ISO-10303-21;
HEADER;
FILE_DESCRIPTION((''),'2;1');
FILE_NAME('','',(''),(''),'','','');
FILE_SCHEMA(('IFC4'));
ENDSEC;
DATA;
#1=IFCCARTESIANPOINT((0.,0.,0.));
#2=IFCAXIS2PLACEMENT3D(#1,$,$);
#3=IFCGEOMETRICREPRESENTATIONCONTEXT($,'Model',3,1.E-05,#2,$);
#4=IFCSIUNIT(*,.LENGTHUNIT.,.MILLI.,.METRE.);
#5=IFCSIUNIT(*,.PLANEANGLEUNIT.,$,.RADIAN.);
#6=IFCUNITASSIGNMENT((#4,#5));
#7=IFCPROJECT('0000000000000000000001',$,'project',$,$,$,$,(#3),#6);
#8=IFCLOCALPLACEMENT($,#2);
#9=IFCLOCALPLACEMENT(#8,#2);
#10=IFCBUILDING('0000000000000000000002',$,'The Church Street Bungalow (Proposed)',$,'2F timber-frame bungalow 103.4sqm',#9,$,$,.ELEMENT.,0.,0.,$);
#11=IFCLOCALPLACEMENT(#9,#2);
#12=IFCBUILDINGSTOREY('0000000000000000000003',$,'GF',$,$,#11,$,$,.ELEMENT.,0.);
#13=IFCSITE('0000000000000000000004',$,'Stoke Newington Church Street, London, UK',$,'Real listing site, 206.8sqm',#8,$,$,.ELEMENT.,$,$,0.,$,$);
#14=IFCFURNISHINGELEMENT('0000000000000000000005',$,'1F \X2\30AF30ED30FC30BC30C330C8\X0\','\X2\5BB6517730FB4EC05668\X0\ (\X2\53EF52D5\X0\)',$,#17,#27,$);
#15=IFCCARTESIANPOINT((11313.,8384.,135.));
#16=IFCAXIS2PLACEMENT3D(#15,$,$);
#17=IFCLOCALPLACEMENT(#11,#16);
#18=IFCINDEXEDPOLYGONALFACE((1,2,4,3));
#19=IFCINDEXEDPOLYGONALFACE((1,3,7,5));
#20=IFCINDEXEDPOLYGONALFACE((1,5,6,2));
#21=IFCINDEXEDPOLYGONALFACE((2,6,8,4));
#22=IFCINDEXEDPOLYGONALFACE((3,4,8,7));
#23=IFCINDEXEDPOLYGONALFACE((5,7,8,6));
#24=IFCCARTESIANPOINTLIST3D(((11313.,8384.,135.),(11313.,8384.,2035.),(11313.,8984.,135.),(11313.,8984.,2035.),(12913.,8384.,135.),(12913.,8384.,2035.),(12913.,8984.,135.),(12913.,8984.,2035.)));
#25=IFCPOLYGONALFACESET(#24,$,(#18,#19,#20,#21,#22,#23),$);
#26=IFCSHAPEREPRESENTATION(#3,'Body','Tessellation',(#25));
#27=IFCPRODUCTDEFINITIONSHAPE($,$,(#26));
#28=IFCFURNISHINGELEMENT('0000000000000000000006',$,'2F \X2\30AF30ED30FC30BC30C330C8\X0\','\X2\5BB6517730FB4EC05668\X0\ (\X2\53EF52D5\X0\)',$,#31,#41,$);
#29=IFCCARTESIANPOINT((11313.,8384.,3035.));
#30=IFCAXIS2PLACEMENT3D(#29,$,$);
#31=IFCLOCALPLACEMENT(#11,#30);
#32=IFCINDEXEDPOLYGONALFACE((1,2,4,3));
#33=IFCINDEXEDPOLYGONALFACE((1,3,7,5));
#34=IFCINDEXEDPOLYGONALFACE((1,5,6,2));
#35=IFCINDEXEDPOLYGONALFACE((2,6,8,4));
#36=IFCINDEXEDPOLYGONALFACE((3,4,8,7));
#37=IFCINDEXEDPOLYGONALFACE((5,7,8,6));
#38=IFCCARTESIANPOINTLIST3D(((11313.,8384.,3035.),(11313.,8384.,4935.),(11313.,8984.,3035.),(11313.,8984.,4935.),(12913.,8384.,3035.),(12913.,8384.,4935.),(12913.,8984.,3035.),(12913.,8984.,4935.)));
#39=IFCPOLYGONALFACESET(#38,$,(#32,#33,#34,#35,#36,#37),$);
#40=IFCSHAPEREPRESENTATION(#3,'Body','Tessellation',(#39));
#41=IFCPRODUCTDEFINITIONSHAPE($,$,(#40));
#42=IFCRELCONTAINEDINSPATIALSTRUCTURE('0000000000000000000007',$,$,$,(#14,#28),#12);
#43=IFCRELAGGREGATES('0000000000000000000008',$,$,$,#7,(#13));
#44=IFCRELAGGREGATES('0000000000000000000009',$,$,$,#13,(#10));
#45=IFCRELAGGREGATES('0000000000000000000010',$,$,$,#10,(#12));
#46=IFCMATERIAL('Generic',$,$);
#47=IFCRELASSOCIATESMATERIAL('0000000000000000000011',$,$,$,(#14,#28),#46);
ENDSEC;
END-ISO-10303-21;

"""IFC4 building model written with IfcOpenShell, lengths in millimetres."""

from ifc_helpers import new_model, si_unit, frame, frame_2d, origin, place, context, project, spatial, rectangle, extrude, material, element, save


model = new_model("IFC4")

# Units and contexts
model_context = context("Model", 3, precision=1e-05, world=origin())
ifc_project = project(units=[si_unit("LENGTHUNIT", "METRE", prefix="MILLI"), si_unit("PLANEANGLEUNIT", "RADIAN")], contexts=[model_context])

# Site, building, storey
site_placement = place(None, origin())
site = spatial("IfcSite", under=ifc_project, at=site_placement, Name="Stoke Newington Church Street, London, UK", ObjectType="Real listing site, 206.8sqm", CompositionType="ELEMENT", RefElevation=0.0)
building_placement = place(site_placement, origin())
building = spatial("IfcBuilding", under=site, at=building_placement, Name="The Church Street Bungalow (Proposed)", ObjectType="2F timber-frame bungalow 103.4sqm", CompositionType="ELEMENT", ElevationOfRefHeight=0.0, ElevationOfTerrain=0.0)
storey_placement = place(building_placement, origin())
storey = spatial("IfcBuildingStorey", under=building, at=storey_placement, Name="GF", CompositionType="ELEMENT", Elevation=0.0)

# Shared definitions
ifc_material_1 = material(Name="Generic")

# Furnishing elements
furnishing_1_placement = place(storey_placement, frame((11313.0, 8384.0, 135.0)))
element("IfcFurnishingElement", 1, at=furnishing_1_placement, inside=storey, material=ifc_material_1, Name="1F クローゼット", Description="家具・什器 (可動)", context=model_context, shape_type="SweptSolid", body=[
    extrude(rectangle(XDim=1600.0, YDim=600.0, at=frame_2d((800.0, 300.0))), frame((11313.0, 8384.0, 135.0)), (0.0, 0.0, 1.0), 1900.0),
])
furnishing_2_placement = place(storey_placement, frame((11313.0, 8384.0, 3035.0)))
element("IfcFurnishingElement", 2, at=furnishing_2_placement, inside=storey, material=ifc_material_1, Name="2F クローゼット", Description="家具・什器 (可動)", context=model_context, shape_type="SweptSolid", body=[
    extrude(rectangle(XDim=1600.0, YDim=600.0, at=frame_2d((800.0, 300.0))), frame((11313.0, 8384.0, 3035.0)), (0.0, 0.0, 1.0), 1900.0),
])

save(model, "model.ifc")
